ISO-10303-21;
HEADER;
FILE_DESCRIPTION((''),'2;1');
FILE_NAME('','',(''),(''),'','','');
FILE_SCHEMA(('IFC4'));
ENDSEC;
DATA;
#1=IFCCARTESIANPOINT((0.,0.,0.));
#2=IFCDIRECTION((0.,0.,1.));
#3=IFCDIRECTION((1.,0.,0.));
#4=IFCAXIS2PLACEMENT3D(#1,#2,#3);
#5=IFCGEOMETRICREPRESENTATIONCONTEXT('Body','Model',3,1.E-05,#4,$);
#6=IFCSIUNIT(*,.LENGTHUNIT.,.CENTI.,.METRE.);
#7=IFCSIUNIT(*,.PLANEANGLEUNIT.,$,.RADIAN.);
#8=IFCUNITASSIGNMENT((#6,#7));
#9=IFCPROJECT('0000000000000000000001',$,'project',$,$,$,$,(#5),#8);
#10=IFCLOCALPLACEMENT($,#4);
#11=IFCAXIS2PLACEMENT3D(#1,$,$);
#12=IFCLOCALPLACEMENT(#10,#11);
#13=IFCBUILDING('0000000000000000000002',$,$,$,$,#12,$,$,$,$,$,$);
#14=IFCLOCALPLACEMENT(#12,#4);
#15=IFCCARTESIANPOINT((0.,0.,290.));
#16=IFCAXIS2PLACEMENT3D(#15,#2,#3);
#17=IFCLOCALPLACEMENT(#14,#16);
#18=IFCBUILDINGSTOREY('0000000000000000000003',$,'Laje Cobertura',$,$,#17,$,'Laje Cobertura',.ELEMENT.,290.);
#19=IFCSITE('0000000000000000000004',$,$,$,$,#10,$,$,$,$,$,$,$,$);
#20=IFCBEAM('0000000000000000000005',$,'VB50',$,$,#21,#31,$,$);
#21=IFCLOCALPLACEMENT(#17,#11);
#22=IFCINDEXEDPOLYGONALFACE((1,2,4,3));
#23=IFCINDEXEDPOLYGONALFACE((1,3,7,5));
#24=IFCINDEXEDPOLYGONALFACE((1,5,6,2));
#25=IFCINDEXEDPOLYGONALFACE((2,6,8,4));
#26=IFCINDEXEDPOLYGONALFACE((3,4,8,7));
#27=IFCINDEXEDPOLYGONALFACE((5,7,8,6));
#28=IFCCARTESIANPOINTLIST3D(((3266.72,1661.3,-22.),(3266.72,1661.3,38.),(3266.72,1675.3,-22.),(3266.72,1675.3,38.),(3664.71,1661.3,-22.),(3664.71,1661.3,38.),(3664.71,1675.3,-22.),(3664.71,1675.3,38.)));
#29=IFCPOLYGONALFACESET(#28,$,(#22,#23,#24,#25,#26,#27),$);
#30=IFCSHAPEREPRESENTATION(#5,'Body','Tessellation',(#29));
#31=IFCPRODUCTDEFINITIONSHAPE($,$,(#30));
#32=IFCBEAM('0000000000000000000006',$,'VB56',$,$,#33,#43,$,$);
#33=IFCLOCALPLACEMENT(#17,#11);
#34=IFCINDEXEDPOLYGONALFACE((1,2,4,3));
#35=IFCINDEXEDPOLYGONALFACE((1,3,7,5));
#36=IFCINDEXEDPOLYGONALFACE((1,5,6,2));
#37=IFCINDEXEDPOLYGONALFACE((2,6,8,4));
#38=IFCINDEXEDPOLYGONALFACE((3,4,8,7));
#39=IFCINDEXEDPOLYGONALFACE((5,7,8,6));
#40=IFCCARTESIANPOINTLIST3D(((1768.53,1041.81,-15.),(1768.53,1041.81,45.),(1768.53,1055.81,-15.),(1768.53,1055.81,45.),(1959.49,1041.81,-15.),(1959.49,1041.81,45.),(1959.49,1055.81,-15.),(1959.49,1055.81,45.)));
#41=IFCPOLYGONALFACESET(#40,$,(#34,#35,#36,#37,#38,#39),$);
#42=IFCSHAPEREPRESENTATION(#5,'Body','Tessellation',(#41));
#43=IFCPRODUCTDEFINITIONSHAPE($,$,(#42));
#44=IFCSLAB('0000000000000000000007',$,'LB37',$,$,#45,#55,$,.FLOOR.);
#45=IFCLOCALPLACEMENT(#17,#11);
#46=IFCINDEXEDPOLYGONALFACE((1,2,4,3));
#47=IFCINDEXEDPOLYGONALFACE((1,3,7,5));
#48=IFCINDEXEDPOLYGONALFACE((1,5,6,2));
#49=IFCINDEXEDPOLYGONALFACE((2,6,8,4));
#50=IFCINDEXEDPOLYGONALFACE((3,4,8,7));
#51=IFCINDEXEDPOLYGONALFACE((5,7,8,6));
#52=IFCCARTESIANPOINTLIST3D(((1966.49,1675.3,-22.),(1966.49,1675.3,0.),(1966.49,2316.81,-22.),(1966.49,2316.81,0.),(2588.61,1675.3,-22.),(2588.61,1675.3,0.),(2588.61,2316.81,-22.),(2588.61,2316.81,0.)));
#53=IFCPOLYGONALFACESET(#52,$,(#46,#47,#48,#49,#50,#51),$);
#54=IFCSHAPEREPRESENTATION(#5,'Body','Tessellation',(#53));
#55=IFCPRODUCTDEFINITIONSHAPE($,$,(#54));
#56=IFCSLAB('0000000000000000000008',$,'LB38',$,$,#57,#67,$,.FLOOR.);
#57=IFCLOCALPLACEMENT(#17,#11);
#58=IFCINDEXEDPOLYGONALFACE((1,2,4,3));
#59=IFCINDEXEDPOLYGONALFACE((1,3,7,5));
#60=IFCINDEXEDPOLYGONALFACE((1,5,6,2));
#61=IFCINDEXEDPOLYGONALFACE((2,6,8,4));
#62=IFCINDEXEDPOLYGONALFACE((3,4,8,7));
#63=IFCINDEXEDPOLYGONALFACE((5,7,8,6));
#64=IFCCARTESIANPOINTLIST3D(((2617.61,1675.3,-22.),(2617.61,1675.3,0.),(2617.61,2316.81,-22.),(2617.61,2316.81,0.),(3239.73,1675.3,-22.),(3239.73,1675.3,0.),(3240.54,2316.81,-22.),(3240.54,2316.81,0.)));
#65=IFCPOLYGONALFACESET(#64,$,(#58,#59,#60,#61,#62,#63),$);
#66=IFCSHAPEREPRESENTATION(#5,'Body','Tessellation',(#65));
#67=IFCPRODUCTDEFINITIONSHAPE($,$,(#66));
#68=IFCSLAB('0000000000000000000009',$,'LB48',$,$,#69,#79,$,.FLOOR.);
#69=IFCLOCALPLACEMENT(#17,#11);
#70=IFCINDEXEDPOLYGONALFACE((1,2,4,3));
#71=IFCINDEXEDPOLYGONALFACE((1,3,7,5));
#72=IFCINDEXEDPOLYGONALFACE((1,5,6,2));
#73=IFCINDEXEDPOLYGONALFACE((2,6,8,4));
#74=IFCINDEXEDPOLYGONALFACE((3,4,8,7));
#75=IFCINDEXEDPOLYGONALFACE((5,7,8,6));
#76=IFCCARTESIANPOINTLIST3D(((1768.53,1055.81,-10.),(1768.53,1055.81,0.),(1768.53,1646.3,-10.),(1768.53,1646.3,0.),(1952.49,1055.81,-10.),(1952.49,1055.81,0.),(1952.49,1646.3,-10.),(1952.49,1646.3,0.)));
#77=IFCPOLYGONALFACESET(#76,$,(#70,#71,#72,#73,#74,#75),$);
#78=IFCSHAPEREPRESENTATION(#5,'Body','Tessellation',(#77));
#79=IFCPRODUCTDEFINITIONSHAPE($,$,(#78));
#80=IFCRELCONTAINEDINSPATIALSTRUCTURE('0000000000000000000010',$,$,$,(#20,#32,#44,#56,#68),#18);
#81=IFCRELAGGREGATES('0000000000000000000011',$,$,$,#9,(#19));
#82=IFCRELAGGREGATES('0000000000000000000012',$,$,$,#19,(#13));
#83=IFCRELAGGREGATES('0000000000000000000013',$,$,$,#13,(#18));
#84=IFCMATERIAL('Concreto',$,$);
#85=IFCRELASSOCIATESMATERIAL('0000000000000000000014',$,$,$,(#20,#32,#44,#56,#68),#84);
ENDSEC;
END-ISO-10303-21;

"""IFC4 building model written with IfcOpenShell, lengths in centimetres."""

from ifc_helpers import new_model, si_unit, frame, origin, origin_with_axes, origin_2d_with_axis, place, context, project, spatial, polyline, rectangle, outline, extrude, material, element, save


model = new_model("IFC4")

# Units and contexts
model_context = context("Model", 3, precision=1e-05, world=origin_with_axes(), identifier="Body")
ifc_project = project(units=[si_unit("LENGTHUNIT", "METRE", prefix="CENTI"), si_unit("PLANEANGLEUNIT", "RADIAN")], contexts=[model_context])

# Site, building, storey
site_placement = place(None, origin_with_axes())
site = spatial("IfcSite", under=ifc_project, at=site_placement)
building_placement = place(site_placement, origin())
building = spatial("IfcBuilding", under=site, at=building_placement)
placement = place(building_placement, origin_with_axes())
storey_placement = place(placement, frame((0.0, 0.0, 290.0), z_axis=(0.0, 0.0, 1.0), x_axis=(1.0, 0.0, 0.0)))
storey = spatial("IfcBuildingStorey", under=building, at=storey_placement, Name="Laje Cobertura", LongName="Laje Cobertura", CompositionType="ELEMENT", Elevation=290.0)

# Shared definitions
ifc_material = material(Name="Concreto")

# Beams
for number, where, z_axis, x_axis, name in (
    (1, (3465.72, 1668.3, 38.0), (0.0, 0.0, 1.0), (1.0, 0.0, 0.0), "VB50"),
):
    element("IfcBeam", number, at=place(storey_placement, frame(where, z_axis=z_axis, x_axis=x_axis)), inside=storey, material=ifc_material, Name=name, context=model_context, shape_type="SolidModel", body=[
        extrude(rectangle(XDim=14.0, YDim=60.0, at=origin_2d_with_axis()), frame((-199.0, 0.0, -30.0), z_axis=(1.0, 0.0, 0.0), x_axis=(0.0, 1.0, 0.0)), (0.0, 0.0, 1.0), 397.99),
    ])
beam_1_placement = place(storey_placement, frame((1864.01, 1048.81, 45.0), z_axis=(0.0, 0.0, 1.0), x_axis=(1.0, 0.0, 0.0)))
element("IfcBeam", 2, at=beam_1_placement, inside=storey, material=ifc_material, Name="VB56", context=model_context, shape_type="SolidModel", body=[
    extrude(rectangle(XDim=14.0, YDim=60.0, at=origin_2d_with_axis()), frame((-95.48, 0.0, -30.0), z_axis=(1.0, 0.0, 0.0), x_axis=(0.0, 1.0, 0.0)), (0.0, 0.0, 1.0), 190.96),
])

# Slabs
slab_1_placement = place(storey_placement, frame((2277.55, 1996.06, 0.0), z_axis=(0.0, 0.0, 1.0), x_axis=(1.0, 0.0, 0.0)))
element("IfcSlab", 3, at=slab_1_placement, inside=storey, material=ifc_material, Name="LB37", PredefinedType="FLOOR", context=model_context, shape_type="SolidModel", body=[
    extrude(outline(polyline([(311.06, -320.75), (311.06, 320.75), (-311.06, 320.75), (-311.06, -320.75), (311.06, -320.75), (311.06, -320.75)])), frame((0.0, 0.0, -22.0), z_axis=(0.0, 0.0, 1.0), x_axis=(1.0, 0.0, 0.0)), (0.0, 0.0, 1.0), 22.0),
])
slab_2_placement = place(storey_placement, frame((2929.07, 1996.06, 0.0), z_axis=(0.0, 0.0, 1.0), x_axis=(1.0, 0.0, 0.0)))
element("IfcSlab", 4, at=slab_2_placement, inside=storey, material=ifc_material, Name="LB38", PredefinedType="FLOOR", context=model_context, shape_type="SolidModel", body=[
    extrude(outline(polyline([(311.46, 320.75), (-311.46, 320.75), (-311.46, -320.75), (310.66, -320.75), (311.46, 320.75), (311.46, 320.75)])), frame((0.0, 0.0, -22.0), z_axis=(0.0, 0.0, 1.0), x_axis=(1.0, 0.0, 0.0)), (0.0, 0.0, 1.0), 22.0),
])
slab_3_placement = place(storey_placement, frame((1860.51, 1351.06, 0.0), z_axis=(0.0, 0.0, 1.0), x_axis=(1.0, 0.0, 0.0)))
element("IfcSlab", 5, at=slab_3_placement, inside=storey, material=ifc_material, Name="LB48", PredefinedType="FLOOR", context=model_context, shape_type="SolidModel", body=[
    extrude(outline(polyline([(91.98, -295.24), (91.98, 295.24), (-91.98, 295.25), (-91.98, -295.24), (91.98, -295.24), (91.98, -295.24)])), frame((0.0, 0.0, -10.0), z_axis=(0.0, 0.0, 1.0), x_axis=(1.0, 0.0, 0.0)), (0.0, 0.0, 1.0), 10.0),
])

save(model, "model.ifc")
